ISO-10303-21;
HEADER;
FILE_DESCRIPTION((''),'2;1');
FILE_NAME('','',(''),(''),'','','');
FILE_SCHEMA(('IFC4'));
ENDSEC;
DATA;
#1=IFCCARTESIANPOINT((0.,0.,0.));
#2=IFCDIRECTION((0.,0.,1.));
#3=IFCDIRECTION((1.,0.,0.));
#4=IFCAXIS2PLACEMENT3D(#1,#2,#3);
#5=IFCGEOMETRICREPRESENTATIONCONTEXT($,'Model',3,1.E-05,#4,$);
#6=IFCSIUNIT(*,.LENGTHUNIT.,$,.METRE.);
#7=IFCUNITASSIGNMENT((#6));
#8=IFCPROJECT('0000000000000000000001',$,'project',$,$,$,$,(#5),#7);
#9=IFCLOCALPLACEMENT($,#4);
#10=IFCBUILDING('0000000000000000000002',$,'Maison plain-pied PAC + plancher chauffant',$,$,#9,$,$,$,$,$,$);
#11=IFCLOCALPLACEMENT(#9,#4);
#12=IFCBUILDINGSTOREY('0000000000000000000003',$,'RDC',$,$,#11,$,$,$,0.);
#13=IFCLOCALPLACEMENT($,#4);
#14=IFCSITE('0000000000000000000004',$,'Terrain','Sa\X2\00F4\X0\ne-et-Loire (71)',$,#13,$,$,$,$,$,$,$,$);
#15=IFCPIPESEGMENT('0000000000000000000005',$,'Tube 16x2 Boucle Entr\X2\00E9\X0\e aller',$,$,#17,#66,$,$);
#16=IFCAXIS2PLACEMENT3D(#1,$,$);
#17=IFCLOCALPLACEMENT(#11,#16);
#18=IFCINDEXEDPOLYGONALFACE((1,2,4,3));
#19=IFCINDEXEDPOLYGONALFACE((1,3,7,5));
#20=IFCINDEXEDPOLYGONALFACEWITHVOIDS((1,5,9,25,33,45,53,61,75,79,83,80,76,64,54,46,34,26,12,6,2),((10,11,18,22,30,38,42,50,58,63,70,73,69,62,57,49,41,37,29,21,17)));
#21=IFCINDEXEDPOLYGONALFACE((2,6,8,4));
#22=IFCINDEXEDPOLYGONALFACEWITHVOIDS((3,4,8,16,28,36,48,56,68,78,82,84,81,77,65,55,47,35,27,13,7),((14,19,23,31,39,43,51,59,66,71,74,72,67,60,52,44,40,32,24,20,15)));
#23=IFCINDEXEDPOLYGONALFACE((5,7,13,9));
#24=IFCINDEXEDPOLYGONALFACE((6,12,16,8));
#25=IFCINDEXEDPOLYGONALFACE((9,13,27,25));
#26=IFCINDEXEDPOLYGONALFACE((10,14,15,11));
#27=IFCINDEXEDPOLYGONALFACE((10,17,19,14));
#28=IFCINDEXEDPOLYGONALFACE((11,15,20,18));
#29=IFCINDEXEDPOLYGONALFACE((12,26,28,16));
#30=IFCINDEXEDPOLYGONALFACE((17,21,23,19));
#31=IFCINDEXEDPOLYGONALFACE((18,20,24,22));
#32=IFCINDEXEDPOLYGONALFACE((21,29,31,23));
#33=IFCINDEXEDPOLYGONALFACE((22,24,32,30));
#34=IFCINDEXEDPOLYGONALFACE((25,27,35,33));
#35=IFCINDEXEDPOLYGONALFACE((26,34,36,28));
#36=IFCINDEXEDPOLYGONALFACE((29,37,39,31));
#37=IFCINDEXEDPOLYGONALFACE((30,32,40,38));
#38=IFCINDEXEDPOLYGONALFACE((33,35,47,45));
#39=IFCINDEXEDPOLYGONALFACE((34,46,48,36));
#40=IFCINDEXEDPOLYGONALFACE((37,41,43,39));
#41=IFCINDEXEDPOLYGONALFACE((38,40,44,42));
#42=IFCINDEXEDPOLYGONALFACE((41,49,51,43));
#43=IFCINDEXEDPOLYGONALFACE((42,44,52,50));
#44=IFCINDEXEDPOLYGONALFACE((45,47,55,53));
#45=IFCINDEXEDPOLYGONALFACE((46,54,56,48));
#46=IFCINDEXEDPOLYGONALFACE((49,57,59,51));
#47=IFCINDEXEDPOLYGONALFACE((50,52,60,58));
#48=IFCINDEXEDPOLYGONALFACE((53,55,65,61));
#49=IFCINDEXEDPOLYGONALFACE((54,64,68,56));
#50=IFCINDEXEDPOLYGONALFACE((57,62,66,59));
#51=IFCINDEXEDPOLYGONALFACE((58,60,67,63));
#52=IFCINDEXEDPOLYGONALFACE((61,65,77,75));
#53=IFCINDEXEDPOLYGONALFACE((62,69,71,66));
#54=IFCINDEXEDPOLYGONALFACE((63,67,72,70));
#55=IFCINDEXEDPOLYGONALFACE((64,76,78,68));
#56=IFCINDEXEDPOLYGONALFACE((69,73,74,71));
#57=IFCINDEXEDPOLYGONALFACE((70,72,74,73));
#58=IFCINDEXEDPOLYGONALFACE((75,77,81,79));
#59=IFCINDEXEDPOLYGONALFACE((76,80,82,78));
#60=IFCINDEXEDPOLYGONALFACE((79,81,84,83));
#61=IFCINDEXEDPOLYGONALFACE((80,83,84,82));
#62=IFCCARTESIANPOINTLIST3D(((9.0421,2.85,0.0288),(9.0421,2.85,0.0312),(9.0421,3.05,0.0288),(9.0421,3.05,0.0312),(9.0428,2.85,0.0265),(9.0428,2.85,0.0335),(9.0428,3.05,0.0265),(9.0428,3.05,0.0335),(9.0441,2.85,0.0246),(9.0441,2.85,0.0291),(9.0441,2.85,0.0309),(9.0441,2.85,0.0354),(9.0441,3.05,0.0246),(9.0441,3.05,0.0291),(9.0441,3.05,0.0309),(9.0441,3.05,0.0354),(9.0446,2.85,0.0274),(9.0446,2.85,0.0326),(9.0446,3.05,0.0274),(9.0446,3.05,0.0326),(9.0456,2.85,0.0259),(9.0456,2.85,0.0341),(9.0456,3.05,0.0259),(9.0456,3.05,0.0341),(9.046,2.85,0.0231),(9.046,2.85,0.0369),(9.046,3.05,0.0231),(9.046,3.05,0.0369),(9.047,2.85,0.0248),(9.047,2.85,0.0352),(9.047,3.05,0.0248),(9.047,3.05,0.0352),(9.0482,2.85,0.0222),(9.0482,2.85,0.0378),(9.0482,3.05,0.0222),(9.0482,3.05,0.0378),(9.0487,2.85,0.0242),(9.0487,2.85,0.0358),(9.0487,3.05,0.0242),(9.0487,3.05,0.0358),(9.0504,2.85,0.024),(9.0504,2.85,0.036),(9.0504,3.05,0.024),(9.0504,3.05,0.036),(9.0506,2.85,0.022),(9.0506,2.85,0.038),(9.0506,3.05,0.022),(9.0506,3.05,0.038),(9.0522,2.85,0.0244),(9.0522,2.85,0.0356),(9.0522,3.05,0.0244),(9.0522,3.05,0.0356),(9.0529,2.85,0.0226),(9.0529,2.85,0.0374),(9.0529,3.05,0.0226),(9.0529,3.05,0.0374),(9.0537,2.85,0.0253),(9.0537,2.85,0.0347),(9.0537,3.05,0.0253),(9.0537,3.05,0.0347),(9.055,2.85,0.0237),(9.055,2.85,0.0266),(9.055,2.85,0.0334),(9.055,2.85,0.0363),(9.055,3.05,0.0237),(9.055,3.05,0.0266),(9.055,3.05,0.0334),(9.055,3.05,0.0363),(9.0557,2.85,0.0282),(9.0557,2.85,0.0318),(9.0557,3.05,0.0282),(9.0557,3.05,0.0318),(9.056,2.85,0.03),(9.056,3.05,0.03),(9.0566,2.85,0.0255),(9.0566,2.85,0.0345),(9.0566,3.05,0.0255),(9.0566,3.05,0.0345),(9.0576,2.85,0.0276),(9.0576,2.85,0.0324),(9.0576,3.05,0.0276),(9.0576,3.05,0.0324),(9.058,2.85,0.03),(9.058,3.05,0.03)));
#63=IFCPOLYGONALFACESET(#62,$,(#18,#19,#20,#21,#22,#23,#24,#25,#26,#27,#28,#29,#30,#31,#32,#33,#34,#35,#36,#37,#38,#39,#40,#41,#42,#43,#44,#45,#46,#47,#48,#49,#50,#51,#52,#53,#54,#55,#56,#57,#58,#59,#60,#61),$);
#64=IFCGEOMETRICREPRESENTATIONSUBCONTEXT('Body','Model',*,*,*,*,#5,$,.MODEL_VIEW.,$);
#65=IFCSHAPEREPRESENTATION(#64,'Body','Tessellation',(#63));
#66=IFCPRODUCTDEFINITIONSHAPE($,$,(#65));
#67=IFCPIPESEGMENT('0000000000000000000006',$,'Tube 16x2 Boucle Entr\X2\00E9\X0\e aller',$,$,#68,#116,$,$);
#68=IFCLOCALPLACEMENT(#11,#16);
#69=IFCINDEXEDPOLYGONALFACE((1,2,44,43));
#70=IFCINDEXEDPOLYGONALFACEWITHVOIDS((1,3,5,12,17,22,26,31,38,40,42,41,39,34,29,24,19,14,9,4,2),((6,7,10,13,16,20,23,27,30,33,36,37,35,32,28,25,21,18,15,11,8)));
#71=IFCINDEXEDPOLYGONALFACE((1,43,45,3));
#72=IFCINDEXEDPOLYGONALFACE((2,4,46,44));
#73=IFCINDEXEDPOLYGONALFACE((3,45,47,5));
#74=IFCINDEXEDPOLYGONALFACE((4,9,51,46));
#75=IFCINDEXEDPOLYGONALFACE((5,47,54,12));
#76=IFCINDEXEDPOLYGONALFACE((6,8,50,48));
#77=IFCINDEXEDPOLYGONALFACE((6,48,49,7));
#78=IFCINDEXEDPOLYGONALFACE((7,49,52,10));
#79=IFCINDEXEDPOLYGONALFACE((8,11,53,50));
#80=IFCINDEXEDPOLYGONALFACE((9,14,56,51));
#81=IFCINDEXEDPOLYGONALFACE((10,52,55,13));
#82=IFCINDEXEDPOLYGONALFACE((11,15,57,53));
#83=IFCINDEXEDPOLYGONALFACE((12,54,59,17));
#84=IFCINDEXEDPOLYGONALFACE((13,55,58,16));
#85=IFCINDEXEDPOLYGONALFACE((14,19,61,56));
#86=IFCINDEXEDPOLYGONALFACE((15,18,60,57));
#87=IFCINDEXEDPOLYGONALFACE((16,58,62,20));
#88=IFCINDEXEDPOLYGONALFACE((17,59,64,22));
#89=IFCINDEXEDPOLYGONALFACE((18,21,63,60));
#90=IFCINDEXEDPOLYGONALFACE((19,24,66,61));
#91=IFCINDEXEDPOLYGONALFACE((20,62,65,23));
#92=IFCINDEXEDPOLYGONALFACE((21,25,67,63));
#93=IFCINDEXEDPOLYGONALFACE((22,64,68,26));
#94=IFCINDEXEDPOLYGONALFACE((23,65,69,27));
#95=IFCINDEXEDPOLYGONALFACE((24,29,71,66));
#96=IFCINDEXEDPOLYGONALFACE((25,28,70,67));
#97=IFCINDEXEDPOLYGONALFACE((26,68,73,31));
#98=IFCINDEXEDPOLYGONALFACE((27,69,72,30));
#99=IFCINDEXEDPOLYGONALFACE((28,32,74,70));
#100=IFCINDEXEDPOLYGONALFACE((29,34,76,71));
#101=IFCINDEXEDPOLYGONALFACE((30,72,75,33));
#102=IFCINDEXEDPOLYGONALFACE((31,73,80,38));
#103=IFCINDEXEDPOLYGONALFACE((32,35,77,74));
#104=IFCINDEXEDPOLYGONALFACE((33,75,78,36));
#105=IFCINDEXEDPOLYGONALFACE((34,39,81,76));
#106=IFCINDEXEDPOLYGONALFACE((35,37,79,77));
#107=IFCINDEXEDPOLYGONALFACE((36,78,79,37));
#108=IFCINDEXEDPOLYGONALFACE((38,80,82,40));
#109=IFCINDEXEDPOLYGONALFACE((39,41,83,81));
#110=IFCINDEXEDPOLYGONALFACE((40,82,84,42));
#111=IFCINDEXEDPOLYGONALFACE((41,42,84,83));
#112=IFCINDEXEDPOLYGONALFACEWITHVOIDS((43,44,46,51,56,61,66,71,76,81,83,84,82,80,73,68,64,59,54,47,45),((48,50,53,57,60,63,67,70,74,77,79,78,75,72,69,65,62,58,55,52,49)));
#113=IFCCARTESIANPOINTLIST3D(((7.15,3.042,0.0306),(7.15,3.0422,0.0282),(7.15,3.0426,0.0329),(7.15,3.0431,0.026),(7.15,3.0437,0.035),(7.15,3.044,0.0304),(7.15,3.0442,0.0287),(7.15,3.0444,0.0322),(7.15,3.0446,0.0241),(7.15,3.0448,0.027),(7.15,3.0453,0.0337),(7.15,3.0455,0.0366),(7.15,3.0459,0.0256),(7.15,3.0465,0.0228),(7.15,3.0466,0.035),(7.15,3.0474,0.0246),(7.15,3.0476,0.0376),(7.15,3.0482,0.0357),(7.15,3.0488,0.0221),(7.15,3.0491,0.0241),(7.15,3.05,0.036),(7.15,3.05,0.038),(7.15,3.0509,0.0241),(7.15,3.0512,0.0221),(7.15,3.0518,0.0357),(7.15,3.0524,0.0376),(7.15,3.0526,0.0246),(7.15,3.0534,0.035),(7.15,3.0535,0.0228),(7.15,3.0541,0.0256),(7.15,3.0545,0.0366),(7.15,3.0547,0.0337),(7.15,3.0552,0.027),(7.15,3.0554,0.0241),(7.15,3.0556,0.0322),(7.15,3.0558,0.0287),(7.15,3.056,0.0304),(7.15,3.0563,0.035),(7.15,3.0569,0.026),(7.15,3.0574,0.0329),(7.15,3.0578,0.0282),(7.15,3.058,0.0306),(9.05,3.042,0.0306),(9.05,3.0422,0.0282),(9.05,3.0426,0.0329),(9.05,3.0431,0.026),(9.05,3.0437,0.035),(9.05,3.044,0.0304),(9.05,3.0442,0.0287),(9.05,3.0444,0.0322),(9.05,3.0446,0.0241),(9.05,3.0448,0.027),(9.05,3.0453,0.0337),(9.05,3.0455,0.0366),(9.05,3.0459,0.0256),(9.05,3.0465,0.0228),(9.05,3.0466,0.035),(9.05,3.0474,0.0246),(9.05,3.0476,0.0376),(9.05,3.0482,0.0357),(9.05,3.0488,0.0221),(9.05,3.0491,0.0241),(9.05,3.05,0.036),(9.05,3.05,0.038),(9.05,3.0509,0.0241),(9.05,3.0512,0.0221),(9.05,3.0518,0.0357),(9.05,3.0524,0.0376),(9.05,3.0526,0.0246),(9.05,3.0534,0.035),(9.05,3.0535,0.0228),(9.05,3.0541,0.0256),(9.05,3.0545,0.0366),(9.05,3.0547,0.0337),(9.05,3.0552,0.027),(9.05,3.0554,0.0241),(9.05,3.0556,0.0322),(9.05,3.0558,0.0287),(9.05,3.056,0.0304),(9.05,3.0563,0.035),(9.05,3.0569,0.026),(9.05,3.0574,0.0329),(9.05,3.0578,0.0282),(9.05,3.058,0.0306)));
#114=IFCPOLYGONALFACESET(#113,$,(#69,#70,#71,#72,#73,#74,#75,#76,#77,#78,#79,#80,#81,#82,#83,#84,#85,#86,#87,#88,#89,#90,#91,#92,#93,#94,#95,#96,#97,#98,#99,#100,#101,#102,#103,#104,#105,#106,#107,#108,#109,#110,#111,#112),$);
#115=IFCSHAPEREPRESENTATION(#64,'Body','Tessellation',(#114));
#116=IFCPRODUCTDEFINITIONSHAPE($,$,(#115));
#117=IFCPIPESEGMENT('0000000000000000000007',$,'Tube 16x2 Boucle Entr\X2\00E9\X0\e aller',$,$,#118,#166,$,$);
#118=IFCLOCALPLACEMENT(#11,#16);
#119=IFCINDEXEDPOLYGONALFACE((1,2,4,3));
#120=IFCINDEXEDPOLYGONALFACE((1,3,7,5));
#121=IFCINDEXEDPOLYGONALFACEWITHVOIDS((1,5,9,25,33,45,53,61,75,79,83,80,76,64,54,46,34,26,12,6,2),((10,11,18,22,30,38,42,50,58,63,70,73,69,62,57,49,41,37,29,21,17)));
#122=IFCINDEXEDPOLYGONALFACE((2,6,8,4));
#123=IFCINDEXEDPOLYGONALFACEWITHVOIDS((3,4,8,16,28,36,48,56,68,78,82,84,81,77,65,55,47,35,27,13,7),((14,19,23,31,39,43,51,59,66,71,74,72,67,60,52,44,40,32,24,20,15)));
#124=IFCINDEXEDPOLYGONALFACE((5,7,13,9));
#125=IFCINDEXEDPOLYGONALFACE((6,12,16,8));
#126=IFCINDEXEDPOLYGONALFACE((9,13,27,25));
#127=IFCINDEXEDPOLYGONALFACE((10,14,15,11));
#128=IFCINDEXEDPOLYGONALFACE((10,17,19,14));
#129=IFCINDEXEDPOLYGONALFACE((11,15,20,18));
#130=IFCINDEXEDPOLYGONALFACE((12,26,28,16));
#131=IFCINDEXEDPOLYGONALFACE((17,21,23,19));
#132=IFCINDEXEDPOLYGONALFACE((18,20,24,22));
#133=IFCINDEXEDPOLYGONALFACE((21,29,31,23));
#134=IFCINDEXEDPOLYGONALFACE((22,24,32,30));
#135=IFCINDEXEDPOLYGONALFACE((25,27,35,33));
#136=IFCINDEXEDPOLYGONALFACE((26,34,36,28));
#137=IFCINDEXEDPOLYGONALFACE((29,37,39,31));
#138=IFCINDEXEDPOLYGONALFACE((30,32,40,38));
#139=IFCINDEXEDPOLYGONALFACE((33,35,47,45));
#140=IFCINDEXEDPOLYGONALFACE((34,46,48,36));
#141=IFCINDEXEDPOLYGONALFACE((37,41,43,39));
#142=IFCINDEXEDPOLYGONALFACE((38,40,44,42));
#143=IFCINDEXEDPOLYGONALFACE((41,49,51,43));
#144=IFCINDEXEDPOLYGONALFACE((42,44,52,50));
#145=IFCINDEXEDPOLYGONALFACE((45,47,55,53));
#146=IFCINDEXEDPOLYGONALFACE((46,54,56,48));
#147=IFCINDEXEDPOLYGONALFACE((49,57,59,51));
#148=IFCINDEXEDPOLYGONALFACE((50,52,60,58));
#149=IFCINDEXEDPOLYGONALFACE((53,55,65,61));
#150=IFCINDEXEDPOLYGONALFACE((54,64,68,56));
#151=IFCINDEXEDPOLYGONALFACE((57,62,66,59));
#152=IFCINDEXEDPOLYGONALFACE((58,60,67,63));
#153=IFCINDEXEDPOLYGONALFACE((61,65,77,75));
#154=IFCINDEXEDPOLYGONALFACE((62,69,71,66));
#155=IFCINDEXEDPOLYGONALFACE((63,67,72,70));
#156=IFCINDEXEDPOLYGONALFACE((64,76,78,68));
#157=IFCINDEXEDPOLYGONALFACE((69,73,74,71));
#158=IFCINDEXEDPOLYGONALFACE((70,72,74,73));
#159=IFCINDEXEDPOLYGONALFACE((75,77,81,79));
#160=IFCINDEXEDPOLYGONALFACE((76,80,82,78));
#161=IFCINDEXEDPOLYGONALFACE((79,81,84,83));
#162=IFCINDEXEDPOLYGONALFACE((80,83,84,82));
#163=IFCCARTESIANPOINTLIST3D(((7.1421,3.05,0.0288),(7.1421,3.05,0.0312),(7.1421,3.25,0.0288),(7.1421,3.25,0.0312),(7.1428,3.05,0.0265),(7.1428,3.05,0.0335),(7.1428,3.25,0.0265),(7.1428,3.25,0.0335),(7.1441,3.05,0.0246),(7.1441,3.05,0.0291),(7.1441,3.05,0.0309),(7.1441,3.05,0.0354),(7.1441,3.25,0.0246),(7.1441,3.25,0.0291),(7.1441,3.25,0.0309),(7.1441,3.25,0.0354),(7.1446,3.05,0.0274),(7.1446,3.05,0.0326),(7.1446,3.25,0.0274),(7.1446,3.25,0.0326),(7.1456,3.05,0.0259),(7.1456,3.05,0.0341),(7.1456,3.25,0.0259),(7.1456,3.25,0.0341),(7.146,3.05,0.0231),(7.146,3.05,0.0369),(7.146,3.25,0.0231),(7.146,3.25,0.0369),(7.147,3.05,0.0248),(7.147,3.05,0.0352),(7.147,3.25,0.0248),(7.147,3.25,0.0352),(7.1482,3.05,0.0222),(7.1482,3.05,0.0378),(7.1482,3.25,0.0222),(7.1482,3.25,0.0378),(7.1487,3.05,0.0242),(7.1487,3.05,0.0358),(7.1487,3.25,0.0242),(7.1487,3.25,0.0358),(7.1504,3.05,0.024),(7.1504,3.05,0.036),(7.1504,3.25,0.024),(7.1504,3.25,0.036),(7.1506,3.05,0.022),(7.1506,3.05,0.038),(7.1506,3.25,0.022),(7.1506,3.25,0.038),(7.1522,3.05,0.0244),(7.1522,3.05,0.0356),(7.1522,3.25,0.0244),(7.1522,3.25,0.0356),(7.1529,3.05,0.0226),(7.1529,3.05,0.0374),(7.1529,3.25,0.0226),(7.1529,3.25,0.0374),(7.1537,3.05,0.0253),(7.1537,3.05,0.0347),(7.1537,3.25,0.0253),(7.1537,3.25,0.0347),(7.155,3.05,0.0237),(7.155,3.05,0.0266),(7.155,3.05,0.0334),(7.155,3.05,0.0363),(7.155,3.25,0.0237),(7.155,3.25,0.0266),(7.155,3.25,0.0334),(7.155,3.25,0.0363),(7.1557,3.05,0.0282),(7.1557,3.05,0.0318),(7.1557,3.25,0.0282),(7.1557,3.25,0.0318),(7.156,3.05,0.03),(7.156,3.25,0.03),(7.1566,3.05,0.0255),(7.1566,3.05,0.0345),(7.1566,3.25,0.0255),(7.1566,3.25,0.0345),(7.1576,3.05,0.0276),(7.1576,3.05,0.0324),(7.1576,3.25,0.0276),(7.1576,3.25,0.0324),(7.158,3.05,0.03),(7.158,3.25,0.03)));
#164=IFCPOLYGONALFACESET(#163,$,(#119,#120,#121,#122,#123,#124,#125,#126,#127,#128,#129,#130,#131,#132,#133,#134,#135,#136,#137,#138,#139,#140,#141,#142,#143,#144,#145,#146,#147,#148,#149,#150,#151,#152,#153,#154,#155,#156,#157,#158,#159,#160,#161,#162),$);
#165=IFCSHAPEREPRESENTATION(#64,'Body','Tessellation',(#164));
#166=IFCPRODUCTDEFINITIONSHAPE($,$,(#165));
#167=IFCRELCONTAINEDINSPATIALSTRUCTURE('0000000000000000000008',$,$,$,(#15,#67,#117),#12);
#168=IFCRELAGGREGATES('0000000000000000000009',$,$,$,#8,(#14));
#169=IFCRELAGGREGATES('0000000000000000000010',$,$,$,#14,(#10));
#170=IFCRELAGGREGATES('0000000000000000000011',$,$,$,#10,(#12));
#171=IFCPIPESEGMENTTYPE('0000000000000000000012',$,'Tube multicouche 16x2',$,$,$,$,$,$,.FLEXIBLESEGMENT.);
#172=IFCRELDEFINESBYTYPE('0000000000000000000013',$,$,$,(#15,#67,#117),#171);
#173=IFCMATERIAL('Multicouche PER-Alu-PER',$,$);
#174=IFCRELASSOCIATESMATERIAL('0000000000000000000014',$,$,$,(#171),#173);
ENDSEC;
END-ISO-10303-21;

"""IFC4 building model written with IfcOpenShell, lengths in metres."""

from ifc_helpers import new_model, si_unit, frame, origin_with_axes, place, context, subcontext, project, spatial, hollow_circle, extrude, material, type_object, element, save


model = new_model("IFC4")

# Units and contexts
model_context = context("Model", 3, precision=1e-05, world=origin_with_axes())
body_context = subcontext(model_context, "Body", "Model", "MODEL_VIEW")
ifc_project = project(units=[si_unit("LENGTHUNIT", "METRE")], contexts=[model_context])

# Site, building, storey
site_placement = place(None, origin_with_axes())
site = spatial("IfcSite", under=ifc_project, at=site_placement, Name="Terrain", Description="Saône-et-Loire (71)")
building_placement = place(None, origin_with_axes())
building = spatial("IfcBuilding", under=site, at=building_placement, Name="Maison plain-pied PAC + plancher chauffant")
storey_placement = place(building_placement, origin_with_axes())
storey = spatial("IfcBuildingStorey", under=building, at=storey_placement, Name="RDC", Elevation=0.0)

# Pipe segments
ifc_material = material(Name="Multicouche PER-Alu-PER")
pipe_segment_type = type_object("IfcPipeSegmentType", Name="Tube multicouche 16x2", PredefinedType="FLEXIBLESEGMENT", material=ifc_material)
pipe_segment_1_placement = place(storey_placement, frame((9.05, 2.85, 0.03), z_axis=(0.0, 1.0, 0.0), x_axis=(1.0, 0.0, 0.0)))
element("IfcPipeSegment", 1, at=pipe_segment_1_placement, inside=storey, type_object=pipe_segment_type, Name="Tube 16x2 Boucle Entrée aller", context=body_context, shape_type="SweptSolid", body=[
    extrude(hollow_circle(Radius=0.008, WallThickness=0.002), origin_with_axes(), (0.0, 0.0, 1.0), 0.2),
])
pipe_segment_2_placement = place(storey_placement, frame((9.05, 3.05, 0.03), z_axis=(-1.0, 0.0, 0.0), x_axis=(0.0, 0.0, 1.0)))
element("IfcPipeSegment", 2, at=pipe_segment_2_placement, inside=storey, type_object=pipe_segment_type, Name="Tube 16x2 Boucle Entrée aller", context=body_context, shape_type="SweptSolid", body=[
    extrude(hollow_circle(Radius=0.008, WallThickness=0.002), origin_with_axes(), (0.0, 0.0, 1.0), 1.9),
])
pipe_segment_3_placement = place(storey_placement, frame((7.15, 3.05, 0.03), z_axis=(0.0, 1.0, 0.0), x_axis=(1.0, 0.0, 0.0)))
element("IfcPipeSegment", 3, at=pipe_segment_3_placement, inside=storey, type_object=pipe_segment_type, Name="Tube 16x2 Boucle Entrée aller", context=body_context, shape_type="SweptSolid", body=[
    extrude(hollow_circle(Radius=0.008, WallThickness=0.002), origin_with_axes(), (0.0, 0.0, 1.0), 0.2),
])

save(model, "model.ifc")
